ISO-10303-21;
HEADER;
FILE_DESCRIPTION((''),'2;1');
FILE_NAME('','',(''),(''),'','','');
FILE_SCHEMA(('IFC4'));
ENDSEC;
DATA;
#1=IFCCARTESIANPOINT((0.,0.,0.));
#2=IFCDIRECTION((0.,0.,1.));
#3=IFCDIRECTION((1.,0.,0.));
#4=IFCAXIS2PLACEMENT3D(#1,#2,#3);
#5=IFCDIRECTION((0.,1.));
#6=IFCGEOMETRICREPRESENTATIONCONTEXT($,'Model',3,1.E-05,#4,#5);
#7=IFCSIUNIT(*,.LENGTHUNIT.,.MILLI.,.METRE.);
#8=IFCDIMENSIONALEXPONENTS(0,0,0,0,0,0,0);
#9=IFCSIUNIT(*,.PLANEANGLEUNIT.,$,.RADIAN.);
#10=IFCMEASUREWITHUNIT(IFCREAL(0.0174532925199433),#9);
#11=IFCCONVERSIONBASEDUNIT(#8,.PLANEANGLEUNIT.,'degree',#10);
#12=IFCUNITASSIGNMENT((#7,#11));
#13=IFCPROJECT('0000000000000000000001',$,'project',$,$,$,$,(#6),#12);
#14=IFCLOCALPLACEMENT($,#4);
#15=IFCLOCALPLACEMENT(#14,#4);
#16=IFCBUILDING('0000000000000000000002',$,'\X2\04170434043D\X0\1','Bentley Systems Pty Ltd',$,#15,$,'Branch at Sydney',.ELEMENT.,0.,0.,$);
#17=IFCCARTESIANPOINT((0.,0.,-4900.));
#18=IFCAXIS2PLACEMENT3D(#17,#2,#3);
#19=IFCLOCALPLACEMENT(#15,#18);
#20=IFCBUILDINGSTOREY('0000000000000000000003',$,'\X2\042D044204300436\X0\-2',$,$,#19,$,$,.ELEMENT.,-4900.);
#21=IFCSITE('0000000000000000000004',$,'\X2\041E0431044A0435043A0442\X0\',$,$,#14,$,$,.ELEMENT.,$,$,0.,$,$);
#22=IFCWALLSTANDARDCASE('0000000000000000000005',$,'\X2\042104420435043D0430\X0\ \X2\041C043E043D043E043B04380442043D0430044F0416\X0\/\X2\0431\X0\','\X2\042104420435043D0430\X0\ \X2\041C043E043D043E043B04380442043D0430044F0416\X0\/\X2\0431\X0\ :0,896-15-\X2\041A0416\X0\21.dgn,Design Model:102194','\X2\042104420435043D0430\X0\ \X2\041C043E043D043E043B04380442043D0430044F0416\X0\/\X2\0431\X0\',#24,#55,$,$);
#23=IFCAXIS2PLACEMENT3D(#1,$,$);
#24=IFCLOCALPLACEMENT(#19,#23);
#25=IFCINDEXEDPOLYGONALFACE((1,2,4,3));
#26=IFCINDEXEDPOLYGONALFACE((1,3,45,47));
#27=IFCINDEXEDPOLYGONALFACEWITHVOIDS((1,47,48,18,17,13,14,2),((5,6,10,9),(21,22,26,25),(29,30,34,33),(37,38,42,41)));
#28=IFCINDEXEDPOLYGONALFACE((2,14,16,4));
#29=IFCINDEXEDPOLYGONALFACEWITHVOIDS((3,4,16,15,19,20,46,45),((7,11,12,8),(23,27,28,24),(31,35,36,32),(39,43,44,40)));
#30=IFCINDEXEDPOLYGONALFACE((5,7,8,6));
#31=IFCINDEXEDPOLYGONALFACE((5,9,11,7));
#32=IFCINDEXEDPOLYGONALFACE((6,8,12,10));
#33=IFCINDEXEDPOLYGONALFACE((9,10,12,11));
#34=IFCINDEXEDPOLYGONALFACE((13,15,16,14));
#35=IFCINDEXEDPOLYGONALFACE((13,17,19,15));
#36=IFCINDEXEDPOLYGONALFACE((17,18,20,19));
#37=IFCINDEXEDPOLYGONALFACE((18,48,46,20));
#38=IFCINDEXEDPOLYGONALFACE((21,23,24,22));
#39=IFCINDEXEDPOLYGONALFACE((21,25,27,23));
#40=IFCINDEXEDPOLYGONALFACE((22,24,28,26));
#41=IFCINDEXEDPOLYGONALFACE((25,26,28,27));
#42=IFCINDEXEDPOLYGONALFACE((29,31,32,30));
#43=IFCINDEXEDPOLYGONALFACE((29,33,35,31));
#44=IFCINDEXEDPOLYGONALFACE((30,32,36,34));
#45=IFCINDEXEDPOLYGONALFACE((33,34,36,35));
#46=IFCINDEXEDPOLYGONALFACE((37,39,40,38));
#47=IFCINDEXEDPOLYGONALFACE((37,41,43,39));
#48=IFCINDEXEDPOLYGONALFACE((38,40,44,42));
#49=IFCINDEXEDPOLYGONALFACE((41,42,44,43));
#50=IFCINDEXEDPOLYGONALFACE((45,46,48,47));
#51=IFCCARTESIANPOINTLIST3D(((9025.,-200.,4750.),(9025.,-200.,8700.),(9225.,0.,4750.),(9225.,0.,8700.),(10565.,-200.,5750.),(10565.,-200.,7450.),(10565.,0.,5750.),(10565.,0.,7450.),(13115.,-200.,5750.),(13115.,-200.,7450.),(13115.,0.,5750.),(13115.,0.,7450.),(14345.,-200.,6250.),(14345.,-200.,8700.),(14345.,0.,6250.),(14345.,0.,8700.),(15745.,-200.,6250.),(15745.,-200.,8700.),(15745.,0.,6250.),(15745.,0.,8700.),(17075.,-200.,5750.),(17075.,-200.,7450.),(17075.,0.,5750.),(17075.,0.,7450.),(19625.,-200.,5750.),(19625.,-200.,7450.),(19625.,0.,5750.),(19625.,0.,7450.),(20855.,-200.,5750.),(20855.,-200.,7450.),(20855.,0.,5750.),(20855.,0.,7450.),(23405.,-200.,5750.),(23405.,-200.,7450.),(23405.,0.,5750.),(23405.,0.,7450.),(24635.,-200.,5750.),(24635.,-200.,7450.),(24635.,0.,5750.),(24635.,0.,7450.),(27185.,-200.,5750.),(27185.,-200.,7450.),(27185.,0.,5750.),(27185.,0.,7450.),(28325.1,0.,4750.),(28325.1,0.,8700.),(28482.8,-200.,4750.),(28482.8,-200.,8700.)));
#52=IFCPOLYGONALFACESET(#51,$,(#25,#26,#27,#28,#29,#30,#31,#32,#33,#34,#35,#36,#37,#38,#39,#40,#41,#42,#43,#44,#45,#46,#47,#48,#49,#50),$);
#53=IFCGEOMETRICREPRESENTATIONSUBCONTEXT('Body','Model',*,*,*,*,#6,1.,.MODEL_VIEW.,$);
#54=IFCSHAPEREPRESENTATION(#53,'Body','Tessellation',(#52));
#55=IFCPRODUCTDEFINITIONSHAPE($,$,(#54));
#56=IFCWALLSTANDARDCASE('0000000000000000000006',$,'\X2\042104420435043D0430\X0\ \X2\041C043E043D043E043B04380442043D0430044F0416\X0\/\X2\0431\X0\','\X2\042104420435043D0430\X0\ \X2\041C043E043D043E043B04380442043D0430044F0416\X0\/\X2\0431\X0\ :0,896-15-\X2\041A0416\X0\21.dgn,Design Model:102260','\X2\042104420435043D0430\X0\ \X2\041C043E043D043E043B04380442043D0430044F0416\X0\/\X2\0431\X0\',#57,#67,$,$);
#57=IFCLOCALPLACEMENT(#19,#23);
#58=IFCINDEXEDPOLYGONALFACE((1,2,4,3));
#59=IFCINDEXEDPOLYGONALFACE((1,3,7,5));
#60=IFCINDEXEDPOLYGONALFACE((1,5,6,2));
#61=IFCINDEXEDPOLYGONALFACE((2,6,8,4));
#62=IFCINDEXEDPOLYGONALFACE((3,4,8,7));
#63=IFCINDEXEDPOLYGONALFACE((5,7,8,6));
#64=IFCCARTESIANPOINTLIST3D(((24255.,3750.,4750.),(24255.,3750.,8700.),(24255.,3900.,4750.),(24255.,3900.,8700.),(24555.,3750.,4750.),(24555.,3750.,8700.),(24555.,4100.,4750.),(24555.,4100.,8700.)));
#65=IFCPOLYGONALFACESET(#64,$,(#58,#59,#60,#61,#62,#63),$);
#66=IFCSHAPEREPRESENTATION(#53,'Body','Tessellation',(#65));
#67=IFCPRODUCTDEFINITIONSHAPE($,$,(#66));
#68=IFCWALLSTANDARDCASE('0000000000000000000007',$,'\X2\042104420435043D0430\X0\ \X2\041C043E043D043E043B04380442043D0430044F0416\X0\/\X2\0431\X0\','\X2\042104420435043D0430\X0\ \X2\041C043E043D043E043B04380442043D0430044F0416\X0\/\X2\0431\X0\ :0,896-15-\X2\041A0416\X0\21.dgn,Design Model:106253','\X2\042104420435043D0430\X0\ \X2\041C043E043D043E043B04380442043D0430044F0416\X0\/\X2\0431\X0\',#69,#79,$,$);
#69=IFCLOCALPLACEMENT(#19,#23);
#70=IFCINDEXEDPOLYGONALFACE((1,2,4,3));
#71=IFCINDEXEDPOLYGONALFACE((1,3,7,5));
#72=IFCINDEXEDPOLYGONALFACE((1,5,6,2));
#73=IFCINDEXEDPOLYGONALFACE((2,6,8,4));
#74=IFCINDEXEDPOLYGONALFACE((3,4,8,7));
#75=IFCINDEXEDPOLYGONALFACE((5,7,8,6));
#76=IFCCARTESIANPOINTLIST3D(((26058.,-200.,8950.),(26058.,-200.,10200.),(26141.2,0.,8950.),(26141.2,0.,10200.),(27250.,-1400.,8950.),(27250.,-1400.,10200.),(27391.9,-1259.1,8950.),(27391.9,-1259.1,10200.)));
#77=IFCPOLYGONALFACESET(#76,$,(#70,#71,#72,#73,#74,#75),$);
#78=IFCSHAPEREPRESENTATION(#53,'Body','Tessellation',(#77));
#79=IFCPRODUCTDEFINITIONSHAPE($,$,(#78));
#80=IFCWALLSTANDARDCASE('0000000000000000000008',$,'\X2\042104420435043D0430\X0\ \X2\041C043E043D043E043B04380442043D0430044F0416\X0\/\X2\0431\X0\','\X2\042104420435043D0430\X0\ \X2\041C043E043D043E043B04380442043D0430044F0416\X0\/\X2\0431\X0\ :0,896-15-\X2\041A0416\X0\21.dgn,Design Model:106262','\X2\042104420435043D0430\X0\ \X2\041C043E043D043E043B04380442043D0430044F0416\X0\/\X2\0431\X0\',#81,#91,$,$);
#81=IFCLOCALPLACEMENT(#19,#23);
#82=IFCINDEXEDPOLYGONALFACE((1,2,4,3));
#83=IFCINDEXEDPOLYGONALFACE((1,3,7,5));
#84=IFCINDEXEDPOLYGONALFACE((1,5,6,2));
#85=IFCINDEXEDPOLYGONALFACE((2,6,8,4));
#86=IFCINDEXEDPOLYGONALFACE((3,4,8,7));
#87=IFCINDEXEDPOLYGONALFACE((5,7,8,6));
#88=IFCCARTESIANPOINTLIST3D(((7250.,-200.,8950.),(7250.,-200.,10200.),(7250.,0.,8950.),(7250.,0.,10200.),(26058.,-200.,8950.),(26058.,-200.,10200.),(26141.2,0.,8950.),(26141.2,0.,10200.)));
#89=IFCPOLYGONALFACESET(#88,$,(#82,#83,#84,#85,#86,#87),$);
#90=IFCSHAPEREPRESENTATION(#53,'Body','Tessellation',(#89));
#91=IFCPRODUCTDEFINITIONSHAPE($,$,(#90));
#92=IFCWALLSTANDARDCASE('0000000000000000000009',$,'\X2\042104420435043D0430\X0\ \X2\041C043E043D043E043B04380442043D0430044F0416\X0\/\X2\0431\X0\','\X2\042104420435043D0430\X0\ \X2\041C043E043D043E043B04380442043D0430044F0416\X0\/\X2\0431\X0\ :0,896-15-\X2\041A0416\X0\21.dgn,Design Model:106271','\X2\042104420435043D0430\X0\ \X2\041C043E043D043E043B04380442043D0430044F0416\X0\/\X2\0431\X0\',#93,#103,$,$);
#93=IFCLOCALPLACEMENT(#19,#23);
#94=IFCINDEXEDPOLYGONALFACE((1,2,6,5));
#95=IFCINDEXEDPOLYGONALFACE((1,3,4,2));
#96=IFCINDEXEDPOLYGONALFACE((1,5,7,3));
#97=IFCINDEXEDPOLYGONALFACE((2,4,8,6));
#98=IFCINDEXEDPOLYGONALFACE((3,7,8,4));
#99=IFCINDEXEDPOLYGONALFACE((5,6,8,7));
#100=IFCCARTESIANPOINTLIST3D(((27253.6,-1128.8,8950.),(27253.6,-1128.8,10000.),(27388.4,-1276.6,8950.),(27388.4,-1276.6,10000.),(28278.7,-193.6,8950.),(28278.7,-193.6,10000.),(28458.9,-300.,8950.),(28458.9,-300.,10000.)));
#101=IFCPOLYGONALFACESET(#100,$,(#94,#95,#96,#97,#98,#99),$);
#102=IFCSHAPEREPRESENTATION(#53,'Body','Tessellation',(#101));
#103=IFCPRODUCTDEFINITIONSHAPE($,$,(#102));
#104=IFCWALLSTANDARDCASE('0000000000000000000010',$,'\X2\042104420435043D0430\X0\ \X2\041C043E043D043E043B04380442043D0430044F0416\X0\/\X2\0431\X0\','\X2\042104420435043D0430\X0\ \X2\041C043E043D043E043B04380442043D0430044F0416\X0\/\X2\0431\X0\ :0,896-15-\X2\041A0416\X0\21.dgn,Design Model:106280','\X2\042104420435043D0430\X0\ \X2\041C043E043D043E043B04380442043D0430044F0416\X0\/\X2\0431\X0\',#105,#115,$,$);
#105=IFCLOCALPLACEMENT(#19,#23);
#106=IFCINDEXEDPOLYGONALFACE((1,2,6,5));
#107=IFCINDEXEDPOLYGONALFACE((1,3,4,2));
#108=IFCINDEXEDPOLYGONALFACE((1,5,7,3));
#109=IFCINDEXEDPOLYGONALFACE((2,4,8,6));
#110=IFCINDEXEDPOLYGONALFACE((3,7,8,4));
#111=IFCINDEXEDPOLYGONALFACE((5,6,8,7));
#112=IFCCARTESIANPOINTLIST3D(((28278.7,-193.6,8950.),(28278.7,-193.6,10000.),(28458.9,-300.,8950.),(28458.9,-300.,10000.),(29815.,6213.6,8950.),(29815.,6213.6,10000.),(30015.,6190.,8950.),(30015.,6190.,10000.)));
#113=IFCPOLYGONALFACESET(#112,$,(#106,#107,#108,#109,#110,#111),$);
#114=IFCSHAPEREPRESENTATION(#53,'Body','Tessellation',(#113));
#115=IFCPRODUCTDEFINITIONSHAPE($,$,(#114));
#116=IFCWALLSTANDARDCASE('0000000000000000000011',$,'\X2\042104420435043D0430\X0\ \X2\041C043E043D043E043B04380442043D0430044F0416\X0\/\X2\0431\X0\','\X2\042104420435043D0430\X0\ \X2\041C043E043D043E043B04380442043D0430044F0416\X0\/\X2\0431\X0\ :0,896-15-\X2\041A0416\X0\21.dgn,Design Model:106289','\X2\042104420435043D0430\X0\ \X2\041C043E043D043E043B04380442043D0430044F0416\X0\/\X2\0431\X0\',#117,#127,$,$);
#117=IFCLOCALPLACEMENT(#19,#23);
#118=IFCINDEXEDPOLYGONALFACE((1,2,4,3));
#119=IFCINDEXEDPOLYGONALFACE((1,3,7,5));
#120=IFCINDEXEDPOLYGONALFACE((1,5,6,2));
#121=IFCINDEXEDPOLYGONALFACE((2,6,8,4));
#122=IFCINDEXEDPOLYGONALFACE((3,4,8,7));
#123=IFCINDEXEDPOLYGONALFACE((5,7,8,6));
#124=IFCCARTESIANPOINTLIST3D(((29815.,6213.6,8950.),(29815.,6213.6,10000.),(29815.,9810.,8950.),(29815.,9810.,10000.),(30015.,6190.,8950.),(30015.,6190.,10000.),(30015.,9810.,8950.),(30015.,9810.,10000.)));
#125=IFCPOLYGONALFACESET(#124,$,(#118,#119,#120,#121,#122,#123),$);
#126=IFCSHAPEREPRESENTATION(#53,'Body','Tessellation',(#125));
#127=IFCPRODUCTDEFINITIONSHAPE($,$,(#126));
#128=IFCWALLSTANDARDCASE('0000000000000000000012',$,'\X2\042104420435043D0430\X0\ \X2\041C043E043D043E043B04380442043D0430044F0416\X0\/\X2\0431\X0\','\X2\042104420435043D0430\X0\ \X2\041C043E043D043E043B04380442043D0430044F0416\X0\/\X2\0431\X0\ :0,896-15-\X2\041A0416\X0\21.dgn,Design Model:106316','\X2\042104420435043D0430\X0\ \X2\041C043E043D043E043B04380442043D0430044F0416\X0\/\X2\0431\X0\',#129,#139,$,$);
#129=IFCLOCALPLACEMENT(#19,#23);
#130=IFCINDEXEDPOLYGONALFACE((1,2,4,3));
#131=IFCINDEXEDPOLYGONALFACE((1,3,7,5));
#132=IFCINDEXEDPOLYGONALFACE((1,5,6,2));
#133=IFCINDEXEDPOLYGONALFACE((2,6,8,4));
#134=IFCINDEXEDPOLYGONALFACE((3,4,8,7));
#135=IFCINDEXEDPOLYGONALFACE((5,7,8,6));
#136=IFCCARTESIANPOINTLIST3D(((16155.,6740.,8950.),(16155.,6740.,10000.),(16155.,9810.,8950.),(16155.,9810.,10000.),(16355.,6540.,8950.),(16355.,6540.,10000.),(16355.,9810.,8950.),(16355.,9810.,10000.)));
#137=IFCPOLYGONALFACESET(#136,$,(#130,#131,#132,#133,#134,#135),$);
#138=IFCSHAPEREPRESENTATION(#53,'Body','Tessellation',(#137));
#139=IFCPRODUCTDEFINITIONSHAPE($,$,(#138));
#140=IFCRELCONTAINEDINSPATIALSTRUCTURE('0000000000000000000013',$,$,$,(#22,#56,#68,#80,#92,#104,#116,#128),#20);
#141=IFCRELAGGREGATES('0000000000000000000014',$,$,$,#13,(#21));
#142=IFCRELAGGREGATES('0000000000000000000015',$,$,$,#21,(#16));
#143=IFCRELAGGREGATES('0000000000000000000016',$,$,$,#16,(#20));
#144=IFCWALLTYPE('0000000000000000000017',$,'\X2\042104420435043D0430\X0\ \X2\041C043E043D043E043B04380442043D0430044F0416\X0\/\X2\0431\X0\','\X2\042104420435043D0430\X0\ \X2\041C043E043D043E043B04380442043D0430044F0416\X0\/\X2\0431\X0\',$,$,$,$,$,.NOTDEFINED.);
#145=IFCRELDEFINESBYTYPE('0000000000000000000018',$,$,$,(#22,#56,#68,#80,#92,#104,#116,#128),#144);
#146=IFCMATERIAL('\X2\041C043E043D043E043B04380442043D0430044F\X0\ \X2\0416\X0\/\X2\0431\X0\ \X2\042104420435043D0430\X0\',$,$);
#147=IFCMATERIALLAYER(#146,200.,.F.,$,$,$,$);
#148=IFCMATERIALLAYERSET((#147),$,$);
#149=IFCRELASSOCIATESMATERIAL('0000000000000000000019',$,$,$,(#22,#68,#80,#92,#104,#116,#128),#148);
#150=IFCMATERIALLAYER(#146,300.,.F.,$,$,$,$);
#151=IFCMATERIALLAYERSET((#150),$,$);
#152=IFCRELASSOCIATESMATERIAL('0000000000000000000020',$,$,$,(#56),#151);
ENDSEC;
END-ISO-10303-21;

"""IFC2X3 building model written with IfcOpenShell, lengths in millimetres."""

from ifc_helpers import new_model, entity, si_unit, converted_unit, direction, frame, frame_2d, origin_with_axes, place, context, subcontext, project, spatial, polyline, rectangle, outline, extrude, material, layer, layer_set, layer_usage, type_object, element, save


model = new_model("IFC2X3")

# Units and contexts
model_context = context("Model", 3, precision=1e-05, world=origin_with_axes(), true_north=direction((0.0, 1.0)))
body_context = subcontext(model_context, "Body", "Model", "MODEL_VIEW", scale=1.0)
ifc_project = project(units=[si_unit("LENGTHUNIT", "METRE", prefix="MILLI"), converted_unit("PLANEANGLEUNIT", "degree", entity("IfcReal", 0.0174532925199433), si_unit("PLANEANGLEUNIT", "RADIAN"), dimensions=[0, 0, 0, 0, 0, 0, 0])], contexts=[model_context])

# Site, building, storey
site_placement = place(None, origin_with_axes())
site = spatial("IfcSite", under=ifc_project, at=site_placement, Name="Объект", CompositionType="ELEMENT", RefElevation=0.0)
building_placement = place(site_placement, origin_with_axes())
building = spatial("IfcBuilding", under=site, at=building_placement, Name="Здн1", Description="Bentley Systems Pty Ltd", LongName="Branch at Sydney", CompositionType="ELEMENT", ElevationOfRefHeight=0.0, ElevationOfTerrain=0.0)
storey_placement = place(building_placement, frame((0.0, 0.0, -4900.0), z_axis=(0.0, 0.0, 1.0), x_axis=(1.0, 0.0, 0.0)))
storey = spatial("IfcBuildingStorey", under=building, at=storey_placement, Name="Этаж-2", CompositionType="ELEMENT", Elevation=-4900.0)

# Shared definitions
ifc_material_1 = material(Name="Монолитная Ж/б Стена")
ifc_layer_1 = layer(ifc_material_1, 200.0, ventilated=False)
ifc_layer_set_1 = layer_set([ifc_layer_1])
ifc_layer_usage_1 = layer_usage(ifc_layer_set_1, "AXIS2", "POSITIVE", 0.0)
wall_type = type_object("IfcWallType", Name="Стена МонолитнаяЖ/б", Description="Стена МонолитнаяЖ/б", PredefinedType="NOTDEFINED")

# Shared definitions
ifc_layer_2 = layer(ifc_material_1, 300.0, ventilated=False)
ifc_layer_set_2 = layer_set([ifc_layer_2])
ifc_layer_usage_2 = layer_usage(ifc_layer_set_2, "AXIS2", "POSITIVE", 0.0)

# Wall, openings
wall_1_placement = place(storey_placement, frame((28482.8, -200.0, 4750.0), z_axis=(0.0, 0.0, 1.0), x_axis=(-1.0, 0.0, 0.0)))
wall_1 = element("IfcWallStandardCase", 1, at=wall_1_placement, inside=storey, type_object=wall_type, material=ifc_layer_usage_1, Name="Стена МонолитнаяЖ/б", Description="Стена МонолитнаяЖ/б :0,896-15-КЖ21.dgn,Design Model:102194", ObjectType="Стена МонолитнаяЖ/б", context=body_context, shape_type="SweptSolid", body=[
    extrude(outline(polyline([(19457.8, 0.0), (0.0, 0.0), (157.7, -200.0), (19257.8, -200.0), (19457.8, 0.0)])), origin_with_axes(), (0.0, 0.0, 1.0), 3950.0),
])
opening_1_placement = place(wall_1_placement, frame((15367.8, -200.0, 1000.0), z_axis=(0.0, 0.0, 1.0), x_axis=(1.0, 0.0, 0.0)))
element("IfcOpeningElement", 2, at=opening_1_placement, cuts=wall_1, ObjectType="Opening", context=body_context, shape_type="SweptSolid", body=[
    extrude(rectangle(XDim=1700.0, YDim=2550.0, at=frame_2d((-1275.0, 850.0), x_axis=(0.0, -1.0))), frame((0.0, 0.0, 0.0), z_axis=(0.0, 1.0, 0.0), x_axis=(-1.0, 0.0, 0.0)), (0.0, 0.0, 1.0), 200.0),
])
opening_2_placement = place(wall_1_placement, frame((8857.8, -200.0, 1000.0), z_axis=(0.0, 0.0, 1.0), x_axis=(1.0, 0.0, 0.0)))
element("IfcOpeningElement", 3, at=opening_2_placement, cuts=wall_1, ObjectType="Opening", context=body_context, shape_type="SweptSolid", body=[
    extrude(rectangle(XDim=1700.0, YDim=2550.0, at=frame_2d((-1275.0, 850.0), x_axis=(0.0, -1.0))), frame((0.0, 0.0, 0.0), z_axis=(0.0, 1.0, 0.0), x_axis=(-1.0, 0.0, 0.0)), (0.0, 0.0, 1.0), 200.0),
])
opening_3_placement = place(wall_1_placement, frame((5077.8, -200.0, 1000.0), z_axis=(0.0, 0.0, 1.0), x_axis=(1.0, 0.0, 0.0)))
element("IfcOpeningElement", 4, at=opening_3_placement, cuts=wall_1, ObjectType="Opening", context=body_context, shape_type="SweptSolid", body=[
    extrude(rectangle(XDim=1700.0, YDim=2550.0, at=frame_2d((-1275.0, 850.0), x_axis=(0.0, -1.0))), frame((0.0, 0.0, 0.0), z_axis=(0.0, 1.0, 0.0), x_axis=(-1.0, 0.0, 0.0)), (0.0, 0.0, 1.0), 200.0),
])
opening_4_placement = place(wall_1_placement, frame((1297.8, -200.0, 1000.0), z_axis=(0.0, 0.0, 1.0), x_axis=(1.0, 0.0, 0.0)))
element("IfcOpeningElement", 5, at=opening_4_placement, cuts=wall_1, ObjectType="Opening", context=body_context, shape_type="SweptSolid", body=[
    extrude(rectangle(XDim=1700.0, YDim=2550.0, at=frame_2d((-1275.0, 850.0), x_axis=(0.0, -1.0))), frame((0.0, 0.0, 0.0), z_axis=(0.0, 1.0, 0.0), x_axis=(-1.0, 0.0, 0.0)), (0.0, 0.0, 1.0), 200.0),
])
opening_5_placement = place(wall_1_placement, frame((12737.8, -200.0, 1500.0), z_axis=(0.0, 0.0, 1.0), x_axis=(1.0, 0.0, 0.0)))
element("IfcOpeningElement", 6, at=opening_5_placement, cuts=wall_1, ObjectType="Opening", context=body_context, shape_type="SweptSolid", body=[
    extrude(rectangle(XDim=2450.0, YDim=1400.0, at=frame_2d((-700.0, 1225.0), x_axis=(0.0, -1.0))), frame((0.0, 0.0, 0.0), z_axis=(0.0, 1.0, 0.0), x_axis=(-1.0, 0.0, 0.0)), (0.0, 0.0, 1.0), 200.0),
])

# Walls
wall_2_placement = place(storey_placement, frame((24555.0, 3750.0, 4750.0), z_axis=(0.0, 0.0, 1.0), x_axis=(0.0, 1.0, 0.0)))
element("IfcWallStandardCase", 7, at=wall_2_placement, inside=storey, type_object=wall_type, material=ifc_layer_usage_2, Name="Стена МонолитнаяЖ/б", Description="Стена МонолитнаяЖ/б :0,896-15-КЖ21.dgn,Design Model:102260", ObjectType="Стена МонолитнаяЖ/б", context=body_context, shape_type="SweptSolid", body=[
    extrude(outline(polyline([(150.0, 300.0), (0.0, 300.0), (0.0, 0.0), (350.0, 0.0), (150.0, 300.0)])), origin_with_axes(), (0.0, 0.0, 1.0), 3950.0),
])
wall_3_placement = place(storey_placement, frame((27250.0, -1400.0, 8950.0), z_axis=(0.0, 0.0, 1.0), x_axis=(-0.704738, 0.709468, 0.0)))
element("IfcWallStandardCase", 8, at=wall_3_placement, inside=storey, type_object=wall_type, material=ifc_layer_usage_1, Name="Стена МонолитнаяЖ/б", Description="Стена МонолитнаяЖ/б :0,896-15-КЖ21.dgn,Design Model:106253", ObjectType="Стена МонолитнаяЖ/б", context=body_context, shape_type="SweptSolid", body=[
    extrude(outline(polyline([(1691.4, 0.0), (0.0, 0.0), (0.0, -200.0), (1774.6, -200.0), (1691.4, 0.0)])), origin_with_axes(), (0.0, 0.0, 1.0), 1250.0),
])
wall_4_placement = place(storey_placement, frame((26058.0, -200.0, 8950.0), z_axis=(0.0, 0.0, 1.0), x_axis=(-1.0, 0.0, 0.0)))
element("IfcWallStandardCase", 9, at=wall_4_placement, inside=storey, type_object=wall_type, material=ifc_layer_usage_1, Name="Стена МонолитнаяЖ/б", Description="Стена МонолитнаяЖ/б :0,896-15-КЖ21.dgn,Design Model:106262", ObjectType="Стена МонолитнаяЖ/б", context=body_context, shape_type="SweptSolid", body=[
    extrude(outline(polyline([(0.0, 0.0), (-83.2, -200.0), (18808.0, -200.0), (18808.0, 0.0), (0.0, 0.0)])), origin_with_axes(), (0.0, 0.0, 1.0), 1250.0),
])
wall_5_placement = place(storey_placement, frame((27388.4, -1276.6, 8950.0), z_axis=(0.0, 0.0, 1.0), x_axis=(0.738765, 0.673963, 0.0)))
element("IfcWallStandardCase", 10, at=wall_5_placement, inside=storey, type_object=wall_type, material=ifc_layer_usage_1, Name="Стена МонолитнаяЖ/б", Description="Стена МонолитнаяЖ/б :0,896-15-КЖ21.dgn,Design Model:106271", ObjectType="Стена МонолитнаяЖ/б", context=body_context, shape_type="SweptSolid", body=[
    extrude(outline(polyline([(1387.6, 200.0), (0.0, 200.0), (0.0, 0.0), (1449.0, 0.0), (1387.6, 200.0)])), origin_with_axes(), (0.0, 0.0, 1.0), 1050.0),
])
wall_6_placement = place(storey_placement, frame((28458.9, -300.0, 8950.0), z_axis=(0.0, 0.0, 1.0), x_axis=(0.233165, 0.972437, 0.0)))
element("IfcWallStandardCase", 11, at=wall_6_placement, inside=storey, type_object=wall_type, material=ifc_layer_usage_1, Name="Стена МонолитнаяЖ/б", Description="Стена МонолитнаяЖ/б :0,896-15-КЖ21.dgn,Design Model:106280", ObjectType="Стена МонолитнаяЖ/б", context=body_context, shape_type="SweptSolid", body=[
    extrude(outline(polyline([(6650.3, 200.0), (61.4, 200.0), (0.0, 0.0), (6673.9, 0.0), (6650.3, 200.0)])), origin_with_axes(), (0.0, 0.0, 1.0), 1050.0),
])
wall_7_placement = place(storey_placement, frame((30015.0, 6190.0, 8950.0), z_axis=(0.0, 0.0, 1.0), x_axis=(0.0, 1.0, 0.0)))
element("IfcWallStandardCase", 12, at=wall_7_placement, inside=storey, type_object=wall_type, material=ifc_layer_usage_1, Name="Стена МонолитнаяЖ/б", Description="Стена МонолитнаяЖ/б :0,896-15-КЖ21.dgn,Design Model:106289", ObjectType="Стена МонолитнаяЖ/б", context=body_context, shape_type="SweptSolid", body=[
    extrude(outline(polyline([(23.6, 200.0), (0.0, 0.0), (3620.0, 0.0), (3620.0, 200.0), (23.6, 200.0)])), origin_with_axes(), (0.0, 0.0, 1.0), 1050.0),
])
wall_8_placement = place(storey_placement, frame((16155.0, 6740.0, 8950.0), z_axis=(0.0, 0.0, 1.0), x_axis=(0.0, 1.0, 0.0)))
element("IfcWallStandardCase", 13, at=wall_8_placement, inside=storey, type_object=wall_type, material=ifc_layer_usage_1, Name="Стена МонолитнаяЖ/б", Description="Стена МонолитнаяЖ/б :0,896-15-КЖ21.dgn,Design Model:106316", ObjectType="Стена МонолитнаяЖ/б", context=body_context, shape_type="SweptSolid", body=[
    extrude(outline(polyline([(0.0, 0.0), (-200.0, -200.0), (3070.0, -200.0), (3070.0, 0.0), (0.0, 0.0)])), origin_with_axes(), (0.0, 0.0, 1.0), 1050.0),
])

save(model, "model.ifc")
